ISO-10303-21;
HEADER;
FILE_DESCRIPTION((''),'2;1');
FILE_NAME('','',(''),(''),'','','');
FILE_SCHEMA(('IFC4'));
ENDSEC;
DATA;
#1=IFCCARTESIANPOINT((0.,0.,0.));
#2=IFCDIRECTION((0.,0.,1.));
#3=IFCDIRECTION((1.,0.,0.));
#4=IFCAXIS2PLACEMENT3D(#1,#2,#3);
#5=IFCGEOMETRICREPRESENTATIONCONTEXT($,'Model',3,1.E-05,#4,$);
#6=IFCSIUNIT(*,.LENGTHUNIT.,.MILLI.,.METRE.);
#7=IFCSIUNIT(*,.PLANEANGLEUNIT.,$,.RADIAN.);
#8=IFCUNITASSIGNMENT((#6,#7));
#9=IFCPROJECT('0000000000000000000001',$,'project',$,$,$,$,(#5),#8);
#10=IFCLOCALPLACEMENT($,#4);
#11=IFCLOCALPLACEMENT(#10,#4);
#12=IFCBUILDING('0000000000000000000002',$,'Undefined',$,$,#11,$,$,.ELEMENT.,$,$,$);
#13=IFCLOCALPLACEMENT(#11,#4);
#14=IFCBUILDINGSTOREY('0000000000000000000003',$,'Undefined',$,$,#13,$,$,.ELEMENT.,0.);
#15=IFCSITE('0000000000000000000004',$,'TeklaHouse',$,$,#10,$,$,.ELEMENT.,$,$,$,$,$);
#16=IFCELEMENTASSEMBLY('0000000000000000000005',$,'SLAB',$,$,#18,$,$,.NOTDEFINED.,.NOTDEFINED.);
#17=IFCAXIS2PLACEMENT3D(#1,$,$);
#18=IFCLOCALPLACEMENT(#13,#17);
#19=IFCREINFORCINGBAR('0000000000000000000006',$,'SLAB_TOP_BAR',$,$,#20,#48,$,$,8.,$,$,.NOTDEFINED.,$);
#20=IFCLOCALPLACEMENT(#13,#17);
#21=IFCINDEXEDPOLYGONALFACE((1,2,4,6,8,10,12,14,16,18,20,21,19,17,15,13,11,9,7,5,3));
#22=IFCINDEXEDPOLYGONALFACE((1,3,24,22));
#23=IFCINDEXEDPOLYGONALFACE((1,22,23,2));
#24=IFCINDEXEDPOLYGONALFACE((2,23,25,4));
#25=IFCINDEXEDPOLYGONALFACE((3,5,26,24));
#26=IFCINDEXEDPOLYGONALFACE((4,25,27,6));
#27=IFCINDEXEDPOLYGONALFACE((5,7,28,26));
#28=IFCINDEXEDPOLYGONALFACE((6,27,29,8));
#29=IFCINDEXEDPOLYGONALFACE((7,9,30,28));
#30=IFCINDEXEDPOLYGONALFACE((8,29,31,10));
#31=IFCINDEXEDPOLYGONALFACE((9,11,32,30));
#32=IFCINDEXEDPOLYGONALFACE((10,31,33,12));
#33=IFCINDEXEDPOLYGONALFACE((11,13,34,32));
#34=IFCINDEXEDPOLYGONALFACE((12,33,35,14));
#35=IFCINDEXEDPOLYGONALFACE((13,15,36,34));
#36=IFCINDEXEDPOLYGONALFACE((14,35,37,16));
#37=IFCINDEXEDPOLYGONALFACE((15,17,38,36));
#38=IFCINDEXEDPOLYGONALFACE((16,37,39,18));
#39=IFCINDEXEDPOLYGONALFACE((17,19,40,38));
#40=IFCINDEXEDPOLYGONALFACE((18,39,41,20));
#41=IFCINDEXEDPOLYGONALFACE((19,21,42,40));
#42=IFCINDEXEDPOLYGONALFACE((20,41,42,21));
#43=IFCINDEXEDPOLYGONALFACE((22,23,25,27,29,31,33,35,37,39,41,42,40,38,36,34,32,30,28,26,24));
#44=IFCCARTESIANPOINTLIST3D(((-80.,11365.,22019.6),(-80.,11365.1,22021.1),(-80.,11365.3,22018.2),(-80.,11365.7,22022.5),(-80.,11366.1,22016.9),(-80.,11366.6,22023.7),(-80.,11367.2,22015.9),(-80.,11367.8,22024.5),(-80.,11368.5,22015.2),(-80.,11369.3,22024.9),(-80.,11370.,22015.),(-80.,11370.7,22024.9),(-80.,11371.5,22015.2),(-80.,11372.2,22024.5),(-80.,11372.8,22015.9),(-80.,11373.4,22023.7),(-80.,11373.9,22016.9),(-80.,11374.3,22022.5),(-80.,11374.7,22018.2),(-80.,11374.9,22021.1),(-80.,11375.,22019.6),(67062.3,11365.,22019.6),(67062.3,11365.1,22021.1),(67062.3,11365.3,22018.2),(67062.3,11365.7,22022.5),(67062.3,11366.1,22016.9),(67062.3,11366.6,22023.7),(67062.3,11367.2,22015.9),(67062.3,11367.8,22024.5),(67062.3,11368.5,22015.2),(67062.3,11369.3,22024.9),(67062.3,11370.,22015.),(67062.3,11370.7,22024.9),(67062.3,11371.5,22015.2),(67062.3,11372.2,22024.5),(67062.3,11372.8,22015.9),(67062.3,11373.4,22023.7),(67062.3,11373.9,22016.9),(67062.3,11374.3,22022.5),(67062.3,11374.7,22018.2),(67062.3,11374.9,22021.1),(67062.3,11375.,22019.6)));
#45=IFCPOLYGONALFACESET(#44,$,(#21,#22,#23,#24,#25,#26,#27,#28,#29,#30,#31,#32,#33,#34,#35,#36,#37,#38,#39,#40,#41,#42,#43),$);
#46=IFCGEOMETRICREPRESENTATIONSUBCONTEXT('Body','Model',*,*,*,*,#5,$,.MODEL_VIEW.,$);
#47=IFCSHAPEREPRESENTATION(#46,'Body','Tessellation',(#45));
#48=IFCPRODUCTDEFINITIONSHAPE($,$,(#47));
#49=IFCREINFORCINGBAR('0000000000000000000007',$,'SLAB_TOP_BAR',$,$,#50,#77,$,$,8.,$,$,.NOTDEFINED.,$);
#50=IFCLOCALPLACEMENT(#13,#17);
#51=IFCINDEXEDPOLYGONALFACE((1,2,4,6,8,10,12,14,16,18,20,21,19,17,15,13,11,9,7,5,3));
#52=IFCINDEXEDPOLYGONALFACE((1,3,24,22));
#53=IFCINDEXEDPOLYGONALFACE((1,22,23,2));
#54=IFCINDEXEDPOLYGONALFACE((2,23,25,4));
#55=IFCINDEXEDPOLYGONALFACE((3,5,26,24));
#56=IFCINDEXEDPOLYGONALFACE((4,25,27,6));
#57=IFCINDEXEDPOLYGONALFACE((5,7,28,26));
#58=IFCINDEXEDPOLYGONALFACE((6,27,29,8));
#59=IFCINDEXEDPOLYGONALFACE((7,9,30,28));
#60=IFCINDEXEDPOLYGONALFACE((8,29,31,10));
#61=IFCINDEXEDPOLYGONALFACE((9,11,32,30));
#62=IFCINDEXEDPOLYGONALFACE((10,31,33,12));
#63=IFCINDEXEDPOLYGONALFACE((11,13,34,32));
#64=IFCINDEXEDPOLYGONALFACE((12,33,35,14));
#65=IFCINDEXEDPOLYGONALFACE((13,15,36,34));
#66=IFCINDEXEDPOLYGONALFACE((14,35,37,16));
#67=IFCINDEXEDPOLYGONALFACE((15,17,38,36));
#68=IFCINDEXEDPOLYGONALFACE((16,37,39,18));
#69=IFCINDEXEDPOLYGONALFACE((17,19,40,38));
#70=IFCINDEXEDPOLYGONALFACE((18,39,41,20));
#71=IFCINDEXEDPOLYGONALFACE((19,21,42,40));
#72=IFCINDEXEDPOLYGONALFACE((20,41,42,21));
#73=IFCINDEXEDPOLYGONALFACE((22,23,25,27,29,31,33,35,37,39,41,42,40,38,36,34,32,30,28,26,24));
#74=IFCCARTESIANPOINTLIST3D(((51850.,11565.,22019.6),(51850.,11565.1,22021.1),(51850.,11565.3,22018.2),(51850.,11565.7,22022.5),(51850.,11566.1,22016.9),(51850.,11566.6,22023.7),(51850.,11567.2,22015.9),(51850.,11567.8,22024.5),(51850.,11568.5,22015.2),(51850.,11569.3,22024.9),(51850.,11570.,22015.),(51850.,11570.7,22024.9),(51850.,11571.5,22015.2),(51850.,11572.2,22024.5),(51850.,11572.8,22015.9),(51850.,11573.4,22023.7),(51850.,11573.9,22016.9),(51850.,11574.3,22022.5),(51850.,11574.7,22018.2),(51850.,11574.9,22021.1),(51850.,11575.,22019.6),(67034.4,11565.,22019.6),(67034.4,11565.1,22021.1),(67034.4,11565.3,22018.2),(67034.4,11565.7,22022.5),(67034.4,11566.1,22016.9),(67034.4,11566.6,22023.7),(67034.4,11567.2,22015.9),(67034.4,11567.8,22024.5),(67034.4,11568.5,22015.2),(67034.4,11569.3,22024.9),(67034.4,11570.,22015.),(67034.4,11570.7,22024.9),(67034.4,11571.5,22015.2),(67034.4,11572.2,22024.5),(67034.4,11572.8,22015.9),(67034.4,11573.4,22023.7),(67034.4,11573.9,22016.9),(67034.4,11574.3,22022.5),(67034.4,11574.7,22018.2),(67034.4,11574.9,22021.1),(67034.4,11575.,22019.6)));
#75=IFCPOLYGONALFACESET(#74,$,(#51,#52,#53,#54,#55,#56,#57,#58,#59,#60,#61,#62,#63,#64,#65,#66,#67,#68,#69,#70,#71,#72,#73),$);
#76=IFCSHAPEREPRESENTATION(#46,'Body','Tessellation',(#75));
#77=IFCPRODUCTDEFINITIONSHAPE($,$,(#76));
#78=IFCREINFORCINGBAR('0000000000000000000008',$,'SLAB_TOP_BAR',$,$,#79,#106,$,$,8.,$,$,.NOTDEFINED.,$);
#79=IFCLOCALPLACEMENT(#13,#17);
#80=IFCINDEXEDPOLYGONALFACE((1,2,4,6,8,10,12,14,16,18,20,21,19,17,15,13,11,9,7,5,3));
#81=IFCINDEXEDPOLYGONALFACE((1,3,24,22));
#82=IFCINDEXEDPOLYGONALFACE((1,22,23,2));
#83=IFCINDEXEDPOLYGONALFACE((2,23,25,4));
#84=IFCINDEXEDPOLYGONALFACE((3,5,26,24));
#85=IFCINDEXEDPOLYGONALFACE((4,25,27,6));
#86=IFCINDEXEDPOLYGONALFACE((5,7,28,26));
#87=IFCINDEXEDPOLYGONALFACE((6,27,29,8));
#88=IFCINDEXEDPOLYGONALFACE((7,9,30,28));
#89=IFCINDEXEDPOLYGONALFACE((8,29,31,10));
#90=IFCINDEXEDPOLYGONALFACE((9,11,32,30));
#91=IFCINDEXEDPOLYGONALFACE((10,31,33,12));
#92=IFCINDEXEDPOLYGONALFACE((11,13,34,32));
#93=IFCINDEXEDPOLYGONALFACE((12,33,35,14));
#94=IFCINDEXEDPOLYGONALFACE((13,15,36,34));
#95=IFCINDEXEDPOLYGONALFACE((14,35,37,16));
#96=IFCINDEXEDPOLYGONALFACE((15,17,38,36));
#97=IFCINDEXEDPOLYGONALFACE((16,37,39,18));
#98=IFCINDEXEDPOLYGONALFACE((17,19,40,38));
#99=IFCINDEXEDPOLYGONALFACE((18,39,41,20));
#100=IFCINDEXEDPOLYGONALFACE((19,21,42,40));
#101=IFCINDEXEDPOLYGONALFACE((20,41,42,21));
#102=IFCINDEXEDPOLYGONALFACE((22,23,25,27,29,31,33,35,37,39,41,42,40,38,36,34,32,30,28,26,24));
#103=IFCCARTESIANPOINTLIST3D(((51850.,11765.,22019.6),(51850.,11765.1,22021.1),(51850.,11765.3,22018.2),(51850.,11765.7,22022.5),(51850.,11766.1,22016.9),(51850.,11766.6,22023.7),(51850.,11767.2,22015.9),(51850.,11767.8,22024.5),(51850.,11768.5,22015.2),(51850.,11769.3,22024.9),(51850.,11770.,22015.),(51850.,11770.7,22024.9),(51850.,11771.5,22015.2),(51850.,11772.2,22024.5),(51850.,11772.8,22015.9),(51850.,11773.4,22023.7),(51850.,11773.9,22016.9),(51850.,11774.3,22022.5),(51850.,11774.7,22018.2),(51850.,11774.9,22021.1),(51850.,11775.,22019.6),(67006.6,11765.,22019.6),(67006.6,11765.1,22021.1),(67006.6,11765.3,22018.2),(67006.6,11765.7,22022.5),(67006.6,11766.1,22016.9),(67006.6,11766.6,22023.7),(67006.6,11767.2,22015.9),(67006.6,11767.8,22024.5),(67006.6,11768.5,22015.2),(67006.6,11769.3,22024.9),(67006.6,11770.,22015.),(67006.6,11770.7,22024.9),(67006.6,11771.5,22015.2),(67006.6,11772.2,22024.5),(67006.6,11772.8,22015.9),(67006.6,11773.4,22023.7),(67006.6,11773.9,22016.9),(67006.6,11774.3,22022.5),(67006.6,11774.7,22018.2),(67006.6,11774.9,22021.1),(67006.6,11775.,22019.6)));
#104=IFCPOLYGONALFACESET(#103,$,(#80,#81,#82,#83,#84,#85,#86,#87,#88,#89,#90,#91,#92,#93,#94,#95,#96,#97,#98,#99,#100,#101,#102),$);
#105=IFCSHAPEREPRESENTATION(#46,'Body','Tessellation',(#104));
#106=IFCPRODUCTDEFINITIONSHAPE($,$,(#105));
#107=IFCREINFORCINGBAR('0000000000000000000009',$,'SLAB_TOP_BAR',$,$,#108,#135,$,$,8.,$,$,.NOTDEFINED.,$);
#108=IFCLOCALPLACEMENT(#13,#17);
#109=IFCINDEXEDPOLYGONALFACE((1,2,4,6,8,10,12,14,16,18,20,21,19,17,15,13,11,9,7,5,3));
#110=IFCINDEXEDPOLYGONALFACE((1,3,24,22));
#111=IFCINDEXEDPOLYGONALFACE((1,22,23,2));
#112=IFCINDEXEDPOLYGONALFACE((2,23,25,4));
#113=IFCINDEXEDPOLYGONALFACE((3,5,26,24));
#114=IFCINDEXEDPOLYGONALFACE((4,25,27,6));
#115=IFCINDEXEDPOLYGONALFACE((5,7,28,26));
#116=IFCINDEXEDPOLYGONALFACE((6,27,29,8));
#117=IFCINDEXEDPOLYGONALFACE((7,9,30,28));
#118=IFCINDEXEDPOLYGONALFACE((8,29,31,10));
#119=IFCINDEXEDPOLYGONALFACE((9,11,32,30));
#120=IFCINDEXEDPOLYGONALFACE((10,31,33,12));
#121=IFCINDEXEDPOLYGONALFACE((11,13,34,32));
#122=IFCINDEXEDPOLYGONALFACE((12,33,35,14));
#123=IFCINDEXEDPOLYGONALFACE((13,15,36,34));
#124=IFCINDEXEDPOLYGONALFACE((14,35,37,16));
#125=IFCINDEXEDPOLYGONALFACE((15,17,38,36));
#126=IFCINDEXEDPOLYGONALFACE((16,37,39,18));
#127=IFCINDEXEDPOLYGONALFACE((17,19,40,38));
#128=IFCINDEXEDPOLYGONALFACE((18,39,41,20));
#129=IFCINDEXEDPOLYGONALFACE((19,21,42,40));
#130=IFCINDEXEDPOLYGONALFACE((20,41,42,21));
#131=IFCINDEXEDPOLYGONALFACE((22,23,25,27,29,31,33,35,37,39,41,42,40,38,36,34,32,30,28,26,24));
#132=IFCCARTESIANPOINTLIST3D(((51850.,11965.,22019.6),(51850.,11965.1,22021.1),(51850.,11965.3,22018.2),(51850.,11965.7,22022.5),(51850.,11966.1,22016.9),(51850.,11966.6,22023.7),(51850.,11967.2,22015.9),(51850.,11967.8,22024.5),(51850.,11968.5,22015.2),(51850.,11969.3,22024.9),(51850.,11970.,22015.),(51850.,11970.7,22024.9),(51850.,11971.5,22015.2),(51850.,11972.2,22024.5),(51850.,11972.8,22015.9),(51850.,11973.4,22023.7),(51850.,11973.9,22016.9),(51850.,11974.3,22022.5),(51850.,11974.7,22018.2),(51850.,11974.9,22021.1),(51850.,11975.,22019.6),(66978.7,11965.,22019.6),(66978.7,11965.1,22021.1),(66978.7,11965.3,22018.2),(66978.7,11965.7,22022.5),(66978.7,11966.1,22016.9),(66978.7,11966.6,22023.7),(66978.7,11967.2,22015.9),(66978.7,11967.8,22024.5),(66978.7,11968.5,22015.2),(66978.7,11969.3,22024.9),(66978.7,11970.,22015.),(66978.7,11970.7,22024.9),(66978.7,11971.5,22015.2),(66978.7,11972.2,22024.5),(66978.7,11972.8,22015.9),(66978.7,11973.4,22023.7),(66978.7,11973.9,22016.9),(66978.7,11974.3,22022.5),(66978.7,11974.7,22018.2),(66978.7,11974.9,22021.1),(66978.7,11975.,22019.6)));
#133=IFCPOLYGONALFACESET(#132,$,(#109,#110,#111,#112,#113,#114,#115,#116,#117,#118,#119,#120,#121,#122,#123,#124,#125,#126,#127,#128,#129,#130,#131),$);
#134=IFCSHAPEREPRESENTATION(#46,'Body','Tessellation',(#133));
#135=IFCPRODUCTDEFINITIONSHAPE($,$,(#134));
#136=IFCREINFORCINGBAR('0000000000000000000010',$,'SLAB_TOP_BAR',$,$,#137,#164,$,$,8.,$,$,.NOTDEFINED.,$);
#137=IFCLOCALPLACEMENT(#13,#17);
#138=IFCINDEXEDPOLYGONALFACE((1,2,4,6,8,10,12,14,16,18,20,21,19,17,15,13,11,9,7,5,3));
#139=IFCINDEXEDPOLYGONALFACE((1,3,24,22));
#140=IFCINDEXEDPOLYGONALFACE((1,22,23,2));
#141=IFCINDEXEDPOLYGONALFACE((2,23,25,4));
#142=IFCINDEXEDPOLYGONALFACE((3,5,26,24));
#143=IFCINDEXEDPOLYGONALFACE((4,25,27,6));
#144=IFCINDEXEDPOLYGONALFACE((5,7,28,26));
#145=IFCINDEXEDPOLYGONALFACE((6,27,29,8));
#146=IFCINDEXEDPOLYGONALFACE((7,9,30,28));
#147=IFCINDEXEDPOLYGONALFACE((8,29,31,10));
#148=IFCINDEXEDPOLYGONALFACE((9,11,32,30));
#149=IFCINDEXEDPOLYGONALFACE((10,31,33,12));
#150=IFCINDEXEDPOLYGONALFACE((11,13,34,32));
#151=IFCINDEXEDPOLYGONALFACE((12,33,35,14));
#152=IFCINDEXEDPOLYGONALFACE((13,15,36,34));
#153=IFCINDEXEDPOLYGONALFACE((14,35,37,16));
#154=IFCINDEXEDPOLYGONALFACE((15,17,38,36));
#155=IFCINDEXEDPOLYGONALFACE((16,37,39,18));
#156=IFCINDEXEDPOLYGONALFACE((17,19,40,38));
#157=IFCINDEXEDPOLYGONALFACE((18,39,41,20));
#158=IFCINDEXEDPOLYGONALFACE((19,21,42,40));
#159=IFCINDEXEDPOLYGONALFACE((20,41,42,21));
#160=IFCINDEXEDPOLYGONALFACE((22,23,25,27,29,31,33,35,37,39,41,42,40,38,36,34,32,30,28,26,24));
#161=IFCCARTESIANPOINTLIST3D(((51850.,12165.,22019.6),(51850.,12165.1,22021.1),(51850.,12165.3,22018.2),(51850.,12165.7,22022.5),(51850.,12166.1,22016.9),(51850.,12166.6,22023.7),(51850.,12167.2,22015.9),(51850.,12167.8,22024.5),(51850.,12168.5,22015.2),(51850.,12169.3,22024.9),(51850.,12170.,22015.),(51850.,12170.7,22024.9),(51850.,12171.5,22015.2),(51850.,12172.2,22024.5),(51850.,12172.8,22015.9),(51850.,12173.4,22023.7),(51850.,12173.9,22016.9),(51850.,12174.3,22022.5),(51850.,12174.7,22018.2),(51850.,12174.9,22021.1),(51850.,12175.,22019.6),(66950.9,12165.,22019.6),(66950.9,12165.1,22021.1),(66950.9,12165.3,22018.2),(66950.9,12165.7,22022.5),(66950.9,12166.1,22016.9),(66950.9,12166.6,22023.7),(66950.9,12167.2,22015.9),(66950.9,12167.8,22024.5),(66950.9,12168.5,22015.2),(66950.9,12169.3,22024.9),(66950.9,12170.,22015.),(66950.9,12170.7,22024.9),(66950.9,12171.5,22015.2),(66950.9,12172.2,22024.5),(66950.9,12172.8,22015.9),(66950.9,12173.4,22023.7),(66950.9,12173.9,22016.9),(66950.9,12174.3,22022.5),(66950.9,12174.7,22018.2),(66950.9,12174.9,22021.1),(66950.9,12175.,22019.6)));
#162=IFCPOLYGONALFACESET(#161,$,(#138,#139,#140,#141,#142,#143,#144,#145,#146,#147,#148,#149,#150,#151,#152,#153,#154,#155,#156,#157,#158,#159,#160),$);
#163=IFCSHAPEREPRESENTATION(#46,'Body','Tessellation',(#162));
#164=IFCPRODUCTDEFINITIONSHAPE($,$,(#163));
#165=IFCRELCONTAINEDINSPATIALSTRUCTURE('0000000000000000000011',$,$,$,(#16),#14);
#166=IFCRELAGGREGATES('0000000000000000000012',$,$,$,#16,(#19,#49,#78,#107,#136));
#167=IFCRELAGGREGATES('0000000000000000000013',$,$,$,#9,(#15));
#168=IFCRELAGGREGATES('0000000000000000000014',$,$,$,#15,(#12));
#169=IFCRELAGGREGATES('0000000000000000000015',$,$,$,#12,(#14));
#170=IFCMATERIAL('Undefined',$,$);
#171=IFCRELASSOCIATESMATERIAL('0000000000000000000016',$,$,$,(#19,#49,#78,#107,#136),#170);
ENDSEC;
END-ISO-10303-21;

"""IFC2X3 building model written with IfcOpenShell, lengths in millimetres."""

from ifc_helpers import new_model, entity, si_unit, frame, origin_with_axes, place, context, subcontext, project, spatial, source, transform, mapped, material, element, aggregate, save


model = new_model("IFC2X3")

# Units and contexts
model_context = context("Model", 3, precision=1e-05, world=origin_with_axes())
body_context = subcontext(model_context, "Body", "Model", "MODEL_VIEW")
ifc_project = project(units=[si_unit("LENGTHUNIT", "METRE", prefix="MILLI"), si_unit("PLANEANGLEUNIT", "RADIAN")], contexts=[model_context])

# Site, building, storey
site_placement = place(None, origin_with_axes())
site = spatial("IfcSite", under=ifc_project, at=site_placement, Name="TeklaHouse", CompositionType="ELEMENT")
building_placement = place(site_placement, origin_with_axes())
building = spatial("IfcBuilding", under=site, at=building_placement, Name="Undefined", CompositionType="ELEMENT")
storey_placement = place(building_placement, origin_with_axes())
storey = spatial("IfcBuildingStorey", under=building, at=storey_placement, Name="Undefined", CompositionType="ELEMENT", Elevation=0.0)

# Shared definitions
ifc_material_1 = material(Name="Undefined")

# Element assembly, reinforcing bars
assembly_1_placement = place(storey_placement, origin_with_axes())
assembly_1 = element("IfcElementAssembly", 1, at=assembly_1_placement, inside=storey, Name="SLAB", AssemblyPlace="NOTDEFINED", PredefinedType="NOTDEFINED")
shared_shape_1 = source(origin_with_axes(), body_context, "Body", "AdvancedSweptSolid", [
    entity("IfcSweptDiskSolid", entity("IfcTrimmedCurve", entity("IfcLine", entity("IfcCartesianPoint", [0.0, 0.0, 0.0]), entity("IfcVector", entity("IfcDirection", [1.0, 0.0, 0.0]), 1.0)), [entity("IfcParameterValue", 0.0)], [entity("IfcParameterValue", 67142.264657)], True, "PARAMETER"), 5.0, None, 0.0, 67142.3),
])
reinforcing_bar_1_placement = place(assembly_1_placement, frame((67062.3, 11370.0, 22020.0), z_axis=(0.0, 0.0, -1.0), x_axis=(-1.0, 0.0, 0.0)))
reinforcing_bar_1 = element("IfcReinforcingBar", 2, at=reinforcing_bar_1_placement, material=ifc_material_1, Name="SLAB_TOP_BAR", BarRole="NOTDEFINED", NominalDiameter=8.0, context=body_context, shape_type="MappedRepresentation", body=[
    mapped(shared_shape_1, transform((0.0, 0.0, 0.0))),
])
shared_shape_2 = source(origin_with_axes(), body_context, "Body", "AdvancedSweptSolid", [
    entity("IfcSweptDiskSolid", entity("IfcTrimmedCurve", entity("IfcLine", entity("IfcCartesianPoint", [0.0, 0.0, 0.0]), entity("IfcVector", entity("IfcDirection", [1.0, 0.0, 0.0]), 1.0)), [entity("IfcParameterValue", 0.0)], [entity("IfcParameterValue", 15184.42238)], True, "PARAMETER"), 5.0, None, 0.0, 15184.4),
])
reinforcing_bar_2_placement = place(assembly_1_placement, frame((67034.4, 11570.0, 22020.0), z_axis=(0.0, 0.0, -1.0), x_axis=(-1.0, 0.0, 0.0)))
reinforcing_bar_2 = element("IfcReinforcingBar", 3, at=reinforcing_bar_2_placement, material=ifc_material_1, Name="SLAB_TOP_BAR", BarRole="NOTDEFINED", NominalDiameter=8.0, context=body_context, shape_type="MappedRepresentation", body=[
    mapped(shared_shape_2, transform((0.0, 0.0, 0.0))),
])
shared_shape_3 = source(origin_with_axes(), body_context, "Body", "AdvancedSweptSolid", [
    entity("IfcSweptDiskSolid", entity("IfcTrimmedCurve", entity("IfcLine", entity("IfcCartesianPoint", [0.0, 0.0, 0.0]), entity("IfcVector", entity("IfcDirection", [1.0, 0.0, 0.0]), 1.0)), [entity("IfcParameterValue", 0.0)], [entity("IfcParameterValue", 15156.575923)], True, "PARAMETER"), 5.0, None, 0.0, 15156.6),
])
reinforcing_bar_3_placement = place(assembly_1_placement, frame((67006.6, 11770.0, 22020.0), z_axis=(0.0, 0.0, -1.0), x_axis=(-1.0, 0.0, 0.0)))
reinforcing_bar_3 = element("IfcReinforcingBar", 4, at=reinforcing_bar_3_placement, material=ifc_material_1, Name="SLAB_TOP_BAR", BarRole="NOTDEFINED", NominalDiameter=8.0, context=body_context, shape_type="MappedRepresentation", body=[
    mapped(shared_shape_3, transform((0.0, 0.0, 0.0))),
])
shared_shape_4 = source(origin_with_axes(), body_context, "Body", "AdvancedSweptSolid", [
    entity("IfcSweptDiskSolid", entity("IfcTrimmedCurve", entity("IfcLine", entity("IfcCartesianPoint", [0.0, 0.0, 0.0]), entity("IfcVector", entity("IfcDirection", [1.0, 0.0, 0.0]), 1.0)), [entity("IfcParameterValue", 0.0)], [entity("IfcParameterValue", 15128.729466)], True, "PARAMETER"), 5.0, None, 0.0, 15128.7),
])
reinforcing_bar_4_placement = place(assembly_1_placement, frame((66978.7, 11970.0, 22020.0), z_axis=(0.0, 0.0, -1.0), x_axis=(-1.0, 0.0, 0.0)))
reinforcing_bar_4 = element("IfcReinforcingBar", 5, at=reinforcing_bar_4_placement, material=ifc_material_1, Name="SLAB_TOP_BAR", BarRole="NOTDEFINED", NominalDiameter=8.0, context=body_context, shape_type="MappedRepresentation", body=[
    mapped(shared_shape_4, transform((0.0, 0.0, 0.0))),
])
shared_shape_5 = source(origin_with_axes(), body_context, "Body", "AdvancedSweptSolid", [
    entity("IfcSweptDiskSolid", entity("IfcTrimmedCurve", entity("IfcLine", entity("IfcCartesianPoint", [0.0, 0.0, 0.0]), entity("IfcVector", entity("IfcDirection", [1.0, 0.0, 0.0]), 1.0)), [entity("IfcParameterValue", 0.0)], [entity("IfcParameterValue", 15100.883009)], True, "PARAMETER"), 5.0, None, 0.0, 15100.9),
])
reinforcing_bar_5_placement = place(assembly_1_placement, frame((66950.9, 12170.0, 22020.0), z_axis=(0.0, 0.0, -1.0), x_axis=(-1.0, 0.0, 0.0)))
reinforcing_bar_5 = element("IfcReinforcingBar", 6, at=reinforcing_bar_5_placement, material=ifc_material_1, Name="SLAB_TOP_BAR", BarRole="NOTDEFINED", NominalDiameter=8.0, context=body_context, shape_type="MappedRepresentation", body=[
    mapped(shared_shape_5, transform((0.0, 0.0, 0.0))),
])
aggregate(assembly_1, [reinforcing_bar_1, reinforcing_bar_2, reinforcing_bar_3, reinforcing_bar_4, reinforcing_bar_5])

save(model, "model.ifc")
